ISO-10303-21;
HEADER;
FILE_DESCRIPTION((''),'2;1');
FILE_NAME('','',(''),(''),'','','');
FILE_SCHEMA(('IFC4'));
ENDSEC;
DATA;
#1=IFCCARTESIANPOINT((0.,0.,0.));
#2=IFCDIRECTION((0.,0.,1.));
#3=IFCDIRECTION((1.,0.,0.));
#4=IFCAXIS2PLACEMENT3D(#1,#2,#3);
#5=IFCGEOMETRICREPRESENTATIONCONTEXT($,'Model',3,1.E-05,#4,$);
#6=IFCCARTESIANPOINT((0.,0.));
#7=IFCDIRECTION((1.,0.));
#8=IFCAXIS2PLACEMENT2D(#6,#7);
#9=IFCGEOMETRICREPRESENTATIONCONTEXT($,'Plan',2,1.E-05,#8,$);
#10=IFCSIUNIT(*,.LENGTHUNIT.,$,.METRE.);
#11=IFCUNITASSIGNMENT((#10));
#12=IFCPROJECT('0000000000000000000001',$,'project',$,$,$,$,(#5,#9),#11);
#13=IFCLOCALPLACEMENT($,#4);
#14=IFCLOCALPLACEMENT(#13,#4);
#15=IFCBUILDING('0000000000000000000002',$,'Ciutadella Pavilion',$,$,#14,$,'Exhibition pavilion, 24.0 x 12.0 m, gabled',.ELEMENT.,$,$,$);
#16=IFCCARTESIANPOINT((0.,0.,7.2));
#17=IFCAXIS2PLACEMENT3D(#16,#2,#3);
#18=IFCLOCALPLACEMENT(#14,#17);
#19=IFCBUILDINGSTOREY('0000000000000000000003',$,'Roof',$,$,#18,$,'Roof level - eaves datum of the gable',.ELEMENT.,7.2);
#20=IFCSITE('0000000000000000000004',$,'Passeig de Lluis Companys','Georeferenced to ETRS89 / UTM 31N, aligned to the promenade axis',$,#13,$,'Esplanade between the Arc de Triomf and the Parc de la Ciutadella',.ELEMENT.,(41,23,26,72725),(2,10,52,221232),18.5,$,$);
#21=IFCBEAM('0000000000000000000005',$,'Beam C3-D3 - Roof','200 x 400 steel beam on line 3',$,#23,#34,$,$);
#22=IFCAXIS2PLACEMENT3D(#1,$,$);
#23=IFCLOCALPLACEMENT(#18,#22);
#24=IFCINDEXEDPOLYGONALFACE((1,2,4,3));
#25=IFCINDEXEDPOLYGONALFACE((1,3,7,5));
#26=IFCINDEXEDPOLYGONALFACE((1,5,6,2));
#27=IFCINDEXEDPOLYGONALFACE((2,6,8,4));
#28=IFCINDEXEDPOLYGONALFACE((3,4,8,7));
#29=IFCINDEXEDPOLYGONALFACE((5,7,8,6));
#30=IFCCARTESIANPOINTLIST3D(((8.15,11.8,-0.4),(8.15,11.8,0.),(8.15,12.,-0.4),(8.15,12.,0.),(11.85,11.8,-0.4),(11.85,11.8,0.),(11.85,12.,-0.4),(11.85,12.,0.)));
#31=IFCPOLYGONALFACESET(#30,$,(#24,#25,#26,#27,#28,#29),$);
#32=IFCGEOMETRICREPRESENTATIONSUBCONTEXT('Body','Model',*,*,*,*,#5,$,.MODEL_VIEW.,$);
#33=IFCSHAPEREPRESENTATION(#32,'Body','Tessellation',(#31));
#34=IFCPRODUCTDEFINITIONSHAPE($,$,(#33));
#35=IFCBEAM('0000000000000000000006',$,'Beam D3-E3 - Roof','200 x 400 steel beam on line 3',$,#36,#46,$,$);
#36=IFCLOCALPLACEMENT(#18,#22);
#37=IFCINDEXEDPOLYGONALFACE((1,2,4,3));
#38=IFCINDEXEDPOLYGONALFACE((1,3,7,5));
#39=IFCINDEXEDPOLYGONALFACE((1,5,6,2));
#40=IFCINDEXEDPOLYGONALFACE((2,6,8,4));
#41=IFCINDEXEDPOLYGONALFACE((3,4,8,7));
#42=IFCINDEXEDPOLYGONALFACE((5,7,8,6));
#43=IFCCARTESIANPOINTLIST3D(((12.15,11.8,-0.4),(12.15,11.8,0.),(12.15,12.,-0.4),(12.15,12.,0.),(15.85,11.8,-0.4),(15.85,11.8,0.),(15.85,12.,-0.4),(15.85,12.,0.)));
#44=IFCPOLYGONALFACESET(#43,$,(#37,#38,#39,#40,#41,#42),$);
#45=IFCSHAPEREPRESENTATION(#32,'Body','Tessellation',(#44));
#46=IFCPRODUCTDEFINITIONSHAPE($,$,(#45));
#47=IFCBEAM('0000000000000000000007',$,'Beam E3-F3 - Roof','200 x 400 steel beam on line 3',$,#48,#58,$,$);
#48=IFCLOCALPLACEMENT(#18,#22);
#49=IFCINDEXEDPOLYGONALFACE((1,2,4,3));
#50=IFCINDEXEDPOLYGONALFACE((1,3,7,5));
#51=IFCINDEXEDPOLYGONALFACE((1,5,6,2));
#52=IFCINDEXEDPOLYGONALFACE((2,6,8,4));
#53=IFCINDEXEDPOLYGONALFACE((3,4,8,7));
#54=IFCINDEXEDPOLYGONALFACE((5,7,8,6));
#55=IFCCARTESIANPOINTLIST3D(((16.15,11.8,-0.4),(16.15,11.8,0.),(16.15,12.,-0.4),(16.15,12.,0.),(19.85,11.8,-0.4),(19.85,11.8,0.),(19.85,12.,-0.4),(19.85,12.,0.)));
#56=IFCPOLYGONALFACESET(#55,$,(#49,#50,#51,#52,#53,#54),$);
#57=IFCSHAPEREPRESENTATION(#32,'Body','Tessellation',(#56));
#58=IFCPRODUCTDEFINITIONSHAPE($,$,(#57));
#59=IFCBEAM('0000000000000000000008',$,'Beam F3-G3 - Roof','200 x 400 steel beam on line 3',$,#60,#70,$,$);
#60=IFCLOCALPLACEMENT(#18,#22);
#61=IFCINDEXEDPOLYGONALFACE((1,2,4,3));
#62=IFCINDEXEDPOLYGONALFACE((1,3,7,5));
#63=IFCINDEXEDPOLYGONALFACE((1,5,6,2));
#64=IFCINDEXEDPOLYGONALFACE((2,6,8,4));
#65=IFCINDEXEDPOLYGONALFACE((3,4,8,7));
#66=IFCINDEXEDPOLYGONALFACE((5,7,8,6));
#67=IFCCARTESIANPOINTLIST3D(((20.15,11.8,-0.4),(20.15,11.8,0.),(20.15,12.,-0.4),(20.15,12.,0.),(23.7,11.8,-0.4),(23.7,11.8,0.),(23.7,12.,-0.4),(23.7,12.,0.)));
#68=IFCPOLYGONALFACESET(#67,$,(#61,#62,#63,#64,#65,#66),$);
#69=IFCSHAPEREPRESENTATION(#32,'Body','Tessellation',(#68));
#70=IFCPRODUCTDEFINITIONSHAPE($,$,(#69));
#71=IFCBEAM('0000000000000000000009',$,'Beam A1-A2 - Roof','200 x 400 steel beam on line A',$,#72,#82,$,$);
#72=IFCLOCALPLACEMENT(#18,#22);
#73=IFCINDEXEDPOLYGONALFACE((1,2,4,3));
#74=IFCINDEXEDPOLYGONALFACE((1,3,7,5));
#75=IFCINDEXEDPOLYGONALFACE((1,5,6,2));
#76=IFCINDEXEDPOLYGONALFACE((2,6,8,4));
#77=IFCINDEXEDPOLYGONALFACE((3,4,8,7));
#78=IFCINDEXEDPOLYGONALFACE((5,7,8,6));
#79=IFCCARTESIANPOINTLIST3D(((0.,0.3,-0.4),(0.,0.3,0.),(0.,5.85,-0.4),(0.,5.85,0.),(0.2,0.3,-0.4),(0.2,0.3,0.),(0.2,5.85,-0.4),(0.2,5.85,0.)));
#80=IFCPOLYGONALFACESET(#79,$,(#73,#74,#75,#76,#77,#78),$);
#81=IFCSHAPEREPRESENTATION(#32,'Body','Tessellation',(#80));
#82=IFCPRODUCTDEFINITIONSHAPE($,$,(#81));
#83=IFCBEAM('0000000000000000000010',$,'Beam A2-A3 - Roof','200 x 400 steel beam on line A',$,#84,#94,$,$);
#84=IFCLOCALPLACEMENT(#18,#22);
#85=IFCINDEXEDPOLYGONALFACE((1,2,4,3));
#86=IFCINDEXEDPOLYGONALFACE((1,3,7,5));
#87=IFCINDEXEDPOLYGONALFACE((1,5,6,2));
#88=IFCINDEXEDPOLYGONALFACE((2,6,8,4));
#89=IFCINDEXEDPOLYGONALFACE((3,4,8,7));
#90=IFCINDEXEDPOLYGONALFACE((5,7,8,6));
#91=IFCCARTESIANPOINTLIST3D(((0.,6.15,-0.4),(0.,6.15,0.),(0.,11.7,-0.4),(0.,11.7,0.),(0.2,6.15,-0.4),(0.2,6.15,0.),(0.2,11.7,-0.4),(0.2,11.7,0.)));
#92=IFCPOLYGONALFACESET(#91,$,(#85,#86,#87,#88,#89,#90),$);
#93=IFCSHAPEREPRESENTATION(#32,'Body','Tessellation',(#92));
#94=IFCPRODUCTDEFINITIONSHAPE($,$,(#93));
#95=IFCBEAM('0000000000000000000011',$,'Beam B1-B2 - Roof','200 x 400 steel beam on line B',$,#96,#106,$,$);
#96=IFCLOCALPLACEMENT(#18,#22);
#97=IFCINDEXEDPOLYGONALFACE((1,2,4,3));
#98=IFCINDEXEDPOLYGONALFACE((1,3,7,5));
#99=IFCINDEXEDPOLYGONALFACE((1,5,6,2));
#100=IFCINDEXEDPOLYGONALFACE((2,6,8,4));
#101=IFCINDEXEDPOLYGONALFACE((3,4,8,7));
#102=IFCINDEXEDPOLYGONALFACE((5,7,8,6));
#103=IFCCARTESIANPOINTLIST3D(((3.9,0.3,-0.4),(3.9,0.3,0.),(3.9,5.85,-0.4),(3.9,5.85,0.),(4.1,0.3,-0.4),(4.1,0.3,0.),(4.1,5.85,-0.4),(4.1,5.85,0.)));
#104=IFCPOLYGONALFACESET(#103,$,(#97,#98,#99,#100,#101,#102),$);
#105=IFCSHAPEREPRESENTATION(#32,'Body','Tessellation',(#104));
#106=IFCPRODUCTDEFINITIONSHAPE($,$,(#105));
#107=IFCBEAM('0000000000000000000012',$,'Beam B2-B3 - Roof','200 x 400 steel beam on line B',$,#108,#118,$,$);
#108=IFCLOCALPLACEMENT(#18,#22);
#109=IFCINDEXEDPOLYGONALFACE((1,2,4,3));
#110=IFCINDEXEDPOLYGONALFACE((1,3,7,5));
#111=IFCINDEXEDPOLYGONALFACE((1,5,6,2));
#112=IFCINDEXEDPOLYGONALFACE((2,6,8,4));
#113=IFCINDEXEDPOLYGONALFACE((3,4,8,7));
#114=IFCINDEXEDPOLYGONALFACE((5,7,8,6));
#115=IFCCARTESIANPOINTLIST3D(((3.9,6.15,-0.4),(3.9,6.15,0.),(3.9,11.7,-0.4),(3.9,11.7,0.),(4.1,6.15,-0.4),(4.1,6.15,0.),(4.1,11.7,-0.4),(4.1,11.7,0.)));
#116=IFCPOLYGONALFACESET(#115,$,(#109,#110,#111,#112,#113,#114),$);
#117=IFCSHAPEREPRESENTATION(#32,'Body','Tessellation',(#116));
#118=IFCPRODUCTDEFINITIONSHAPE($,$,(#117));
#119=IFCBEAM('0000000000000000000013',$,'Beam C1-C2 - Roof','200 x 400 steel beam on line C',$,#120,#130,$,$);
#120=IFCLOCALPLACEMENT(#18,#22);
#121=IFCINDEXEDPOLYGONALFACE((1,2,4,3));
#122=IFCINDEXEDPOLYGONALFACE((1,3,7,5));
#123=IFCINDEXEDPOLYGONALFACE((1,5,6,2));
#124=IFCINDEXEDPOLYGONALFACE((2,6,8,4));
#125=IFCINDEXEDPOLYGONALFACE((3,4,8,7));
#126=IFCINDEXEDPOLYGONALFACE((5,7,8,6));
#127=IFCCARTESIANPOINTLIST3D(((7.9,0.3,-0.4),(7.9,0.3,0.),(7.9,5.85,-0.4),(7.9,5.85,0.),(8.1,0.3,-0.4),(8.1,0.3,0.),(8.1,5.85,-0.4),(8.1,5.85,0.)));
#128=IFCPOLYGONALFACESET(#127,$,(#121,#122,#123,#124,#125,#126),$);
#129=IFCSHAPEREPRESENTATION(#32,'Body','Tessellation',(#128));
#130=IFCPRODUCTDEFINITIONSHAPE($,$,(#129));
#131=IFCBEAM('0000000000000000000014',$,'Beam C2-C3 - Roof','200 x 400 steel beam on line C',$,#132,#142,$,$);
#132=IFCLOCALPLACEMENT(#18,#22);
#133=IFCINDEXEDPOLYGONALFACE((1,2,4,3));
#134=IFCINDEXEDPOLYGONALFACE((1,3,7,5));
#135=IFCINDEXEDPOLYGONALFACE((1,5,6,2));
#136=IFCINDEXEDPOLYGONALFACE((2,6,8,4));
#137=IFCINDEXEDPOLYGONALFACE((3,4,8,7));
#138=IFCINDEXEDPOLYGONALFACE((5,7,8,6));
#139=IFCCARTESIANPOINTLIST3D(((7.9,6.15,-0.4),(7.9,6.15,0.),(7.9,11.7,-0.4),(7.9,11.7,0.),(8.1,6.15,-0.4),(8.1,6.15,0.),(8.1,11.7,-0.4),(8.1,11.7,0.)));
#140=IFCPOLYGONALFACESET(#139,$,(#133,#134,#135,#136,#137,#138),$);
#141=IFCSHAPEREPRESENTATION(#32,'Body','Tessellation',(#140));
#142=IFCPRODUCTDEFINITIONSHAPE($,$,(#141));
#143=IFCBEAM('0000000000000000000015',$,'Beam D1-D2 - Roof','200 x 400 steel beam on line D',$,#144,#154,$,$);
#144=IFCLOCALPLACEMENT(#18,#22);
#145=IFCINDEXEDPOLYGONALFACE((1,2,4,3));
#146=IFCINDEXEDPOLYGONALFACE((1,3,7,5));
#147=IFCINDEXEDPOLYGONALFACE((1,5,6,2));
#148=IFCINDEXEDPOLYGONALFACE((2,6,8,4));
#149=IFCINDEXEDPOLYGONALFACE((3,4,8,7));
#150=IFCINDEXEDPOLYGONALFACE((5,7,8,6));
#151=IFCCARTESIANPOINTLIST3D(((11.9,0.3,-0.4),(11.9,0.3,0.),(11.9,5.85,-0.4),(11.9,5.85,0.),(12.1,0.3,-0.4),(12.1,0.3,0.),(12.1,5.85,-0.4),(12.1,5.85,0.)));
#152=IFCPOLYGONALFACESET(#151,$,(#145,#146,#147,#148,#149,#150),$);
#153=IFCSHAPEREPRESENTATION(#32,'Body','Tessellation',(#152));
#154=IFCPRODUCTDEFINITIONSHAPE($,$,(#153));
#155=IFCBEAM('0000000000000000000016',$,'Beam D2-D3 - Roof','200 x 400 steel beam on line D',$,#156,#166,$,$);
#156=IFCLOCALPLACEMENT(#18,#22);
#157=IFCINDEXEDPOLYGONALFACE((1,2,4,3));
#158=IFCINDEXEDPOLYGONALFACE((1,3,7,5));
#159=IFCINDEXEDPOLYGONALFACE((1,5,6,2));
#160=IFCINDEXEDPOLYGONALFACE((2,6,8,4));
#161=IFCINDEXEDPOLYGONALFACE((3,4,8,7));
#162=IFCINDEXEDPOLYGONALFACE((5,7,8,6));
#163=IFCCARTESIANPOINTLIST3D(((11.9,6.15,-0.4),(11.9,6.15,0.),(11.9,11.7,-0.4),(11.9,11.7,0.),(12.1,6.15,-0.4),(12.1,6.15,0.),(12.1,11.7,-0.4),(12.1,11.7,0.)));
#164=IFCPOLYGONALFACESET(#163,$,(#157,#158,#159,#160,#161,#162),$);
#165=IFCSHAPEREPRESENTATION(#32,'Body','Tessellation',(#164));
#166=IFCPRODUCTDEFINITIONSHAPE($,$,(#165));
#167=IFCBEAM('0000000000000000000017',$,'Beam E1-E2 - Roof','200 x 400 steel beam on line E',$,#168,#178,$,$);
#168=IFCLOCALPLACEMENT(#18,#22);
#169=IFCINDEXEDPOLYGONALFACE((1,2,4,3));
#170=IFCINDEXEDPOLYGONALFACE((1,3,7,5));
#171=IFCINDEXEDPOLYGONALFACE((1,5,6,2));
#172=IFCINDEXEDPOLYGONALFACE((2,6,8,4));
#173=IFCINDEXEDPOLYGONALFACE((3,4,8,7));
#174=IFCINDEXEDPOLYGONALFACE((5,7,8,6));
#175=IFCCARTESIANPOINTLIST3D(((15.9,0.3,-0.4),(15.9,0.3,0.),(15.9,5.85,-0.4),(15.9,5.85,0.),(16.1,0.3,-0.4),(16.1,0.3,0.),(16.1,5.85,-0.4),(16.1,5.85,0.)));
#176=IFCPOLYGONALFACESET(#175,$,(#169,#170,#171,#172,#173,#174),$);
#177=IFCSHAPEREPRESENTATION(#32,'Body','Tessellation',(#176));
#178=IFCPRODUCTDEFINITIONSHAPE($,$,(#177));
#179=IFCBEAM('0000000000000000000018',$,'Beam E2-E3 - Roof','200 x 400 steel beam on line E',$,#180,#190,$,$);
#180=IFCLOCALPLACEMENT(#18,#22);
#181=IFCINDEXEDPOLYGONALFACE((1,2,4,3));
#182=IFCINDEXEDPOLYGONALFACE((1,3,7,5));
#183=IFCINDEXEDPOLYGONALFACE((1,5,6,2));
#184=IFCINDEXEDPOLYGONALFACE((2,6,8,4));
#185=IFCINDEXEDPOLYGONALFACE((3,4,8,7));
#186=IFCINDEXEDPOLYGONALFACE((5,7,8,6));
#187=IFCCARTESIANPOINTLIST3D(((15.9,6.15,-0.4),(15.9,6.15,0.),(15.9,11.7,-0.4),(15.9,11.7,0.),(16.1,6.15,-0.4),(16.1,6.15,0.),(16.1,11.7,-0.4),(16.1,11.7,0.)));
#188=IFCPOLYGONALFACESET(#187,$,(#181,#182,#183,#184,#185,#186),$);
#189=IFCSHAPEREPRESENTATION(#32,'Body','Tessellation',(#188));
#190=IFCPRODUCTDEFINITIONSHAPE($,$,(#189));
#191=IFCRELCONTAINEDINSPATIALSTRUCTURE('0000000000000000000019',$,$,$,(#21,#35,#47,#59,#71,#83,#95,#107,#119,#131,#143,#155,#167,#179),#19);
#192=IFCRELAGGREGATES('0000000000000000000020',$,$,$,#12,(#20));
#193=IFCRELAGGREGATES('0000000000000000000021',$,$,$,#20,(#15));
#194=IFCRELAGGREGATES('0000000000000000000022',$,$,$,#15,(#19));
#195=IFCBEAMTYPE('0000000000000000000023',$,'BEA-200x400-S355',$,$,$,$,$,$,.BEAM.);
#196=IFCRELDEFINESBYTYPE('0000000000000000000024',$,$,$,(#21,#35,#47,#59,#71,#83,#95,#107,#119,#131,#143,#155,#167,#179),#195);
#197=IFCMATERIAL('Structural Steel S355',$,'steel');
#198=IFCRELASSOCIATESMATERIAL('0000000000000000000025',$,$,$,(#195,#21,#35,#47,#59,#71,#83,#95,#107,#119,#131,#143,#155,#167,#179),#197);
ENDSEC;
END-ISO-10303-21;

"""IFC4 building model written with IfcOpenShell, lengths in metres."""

from ifc_helpers import new_model, si_unit, frame, origin_with_axes, origin_2d_with_axis, place, context, subcontext, project, spatial, line, indexed_curve, rectangle, outline, extrude, material, material_profile, profile_set, profile_usage, type_object, element, save


model = new_model("IFC4")

# Units and contexts
model_context = context("Model", 3, precision=1e-05, world=origin_with_axes())
plan_context = context("Plan", 2, precision=1e-05, world=origin_2d_with_axis())
body_context = subcontext(model_context, "Body", "Model", "MODEL_VIEW")
ifc_project = project(units=[si_unit("LENGTHUNIT", "METRE")], contexts=[model_context, plan_context])

# Site, building, storey
site_placement = place(None, origin_with_axes())
site = spatial("IfcSite", under=ifc_project, at=site_placement, Name="Passeig de Lluis Companys", Description="Georeferenced to ETRS89 / UTM 31N, aligned to the promenade axis", LongName="Esplanade between the Arc de Triomf and the Parc de la Ciutadella", CompositionType="ELEMENT", RefLatitude=(41, 23, 26, 72725), RefLongitude=(2, 10, 52, 221232), RefElevation=18.5)
building_placement = place(site_placement, origin_with_axes())
building = spatial("IfcBuilding", under=site, at=building_placement, Name="Ciutadella Pavilion", LongName="Exhibition pavilion, 24.0 x 12.0 m, gabled", CompositionType="ELEMENT")
storey_placement = place(building_placement, frame((0.0, 0.0, 7.2), z_axis=(0.0, 0.0, 1.0), x_axis=(1.0, 0.0, 0.0)))
storey = spatial("IfcBuildingStorey", under=building, at=storey_placement, Name="Roof", LongName="Roof level - eaves datum of the gable", CompositionType="ELEMENT", Elevation=7.2)

# Beams
ifc_material_1 = material(Name="Structural Steel S355", Category="steel")
ifc_material_profile = material_profile(ifc_material_1, rectangle(XDim=0.2, YDim=0.4))
ifc_profile_set = profile_set([ifc_material_profile], Name="BEA-200x400-S355")
beam_type = type_object("IfcBeamType", Name="BEA-200x400-S355", PredefinedType="BEAM", material=ifc_profile_set)
ifc_profile_usage_1 = profile_usage(ifc_profile_set)
beam_1_placement = place(storey_placement, frame((8.15, 11.8, -0.4), z_axis=(1.0, 0.0, 0.0), x_axis=(0.0, 1.0, 0.0)))
element("IfcBeam", 1, at=beam_1_placement, inside=storey, type_object=beam_type, material=ifc_profile_usage_1, Name="Beam C3-D3 - Roof", Description="200 x 400 steel beam on line 3", context=body_context, shape_type="SweptSolid", body=[
    extrude(outline(indexed_curve([(0.0, 0.0), (0.2, 0.0), (0.2, 0.4), (0.0, 0.4)], segments=[line(1, 2, 3, 4, 1)])), origin_with_axes(), (0.0, 0.0, 1.0), 3.7),
])
ifc_profile_usage_2 = profile_usage(ifc_profile_set)
beam_2_placement = place(storey_placement, frame((12.15, 11.8, -0.4), z_axis=(1.0, 0.0, 0.0), x_axis=(0.0, 1.0, 0.0)))
element("IfcBeam", 2, at=beam_2_placement, inside=storey, type_object=beam_type, material=ifc_profile_usage_2, Name="Beam D3-E3 - Roof", Description="200 x 400 steel beam on line 3", context=body_context, shape_type="SweptSolid", body=[
    extrude(outline(indexed_curve([(0.0, 0.0), (0.2, 0.0), (0.2, 0.4), (0.0, 0.4)], segments=[line(1, 2, 3, 4, 1)])), origin_with_axes(), (0.0, 0.0, 1.0), 3.7),
])
ifc_profile_usage_3 = profile_usage(ifc_profile_set)
beam_3_placement = place(storey_placement, frame((16.15, 11.8, -0.4), z_axis=(1.0, 0.0, 0.0), x_axis=(0.0, 1.0, 0.0)))
element("IfcBeam", 3, at=beam_3_placement, inside=storey, type_object=beam_type, material=ifc_profile_usage_3, Name="Beam E3-F3 - Roof", Description="200 x 400 steel beam on line 3", context=body_context, shape_type="SweptSolid", body=[
    extrude(outline(indexed_curve([(0.0, 0.0), (0.2, 0.0), (0.2, 0.4), (0.0, 0.4)], segments=[line(1, 2, 3, 4, 1)])), origin_with_axes(), (0.0, 0.0, 1.0), 3.7),
])
ifc_profile_usage_4 = profile_usage(ifc_profile_set)
beam_4_placement = place(storey_placement, frame((20.15, 11.8, -0.4), z_axis=(1.0, 0.0, 0.0), x_axis=(0.0, 1.0, 0.0)))
element("IfcBeam", 4, at=beam_4_placement, inside=storey, type_object=beam_type, material=ifc_profile_usage_4, Name="Beam F3-G3 - Roof", Description="200 x 400 steel beam on line 3", context=body_context, shape_type="SweptSolid", body=[
    extrude(outline(indexed_curve([(0.0, 0.0), (0.2, 0.0), (0.2, 0.4), (0.0, 0.4)], segments=[line(1, 2, 3, 4, 1)])), origin_with_axes(), (0.0, 0.0, 1.0), 3.55),
])
ifc_profile_usage_5 = profile_usage(ifc_profile_set)
beam_5_placement = place(storey_placement, frame((0.0, 0.3, -0.4), z_axis=(0.0, 1.0, 0.0), x_axis=(0.0, 0.0, 1.0)))
element("IfcBeam", 5, at=beam_5_placement, inside=storey, type_object=beam_type, material=ifc_profile_usage_5, Name="Beam A1-A2 - Roof", Description="200 x 400 steel beam on line A", context=body_context, shape_type="SweptSolid", body=[
    extrude(outline(indexed_curve([(0.0, 0.0), (0.4, 0.0), (0.4, 0.2), (0.0, 0.2)], segments=[line(1, 2, 3, 4, 1)])), origin_with_axes(), (0.0, 0.0, 1.0), 5.55),
])
ifc_profile_usage_6 = profile_usage(ifc_profile_set)
beam_6_placement = place(storey_placement, frame((0.0, 6.15, -0.4), z_axis=(0.0, 1.0, 0.0), x_axis=(0.0, 0.0, 1.0)))
element("IfcBeam", 6, at=beam_6_placement, inside=storey, type_object=beam_type, material=ifc_profile_usage_6, Name="Beam A2-A3 - Roof", Description="200 x 400 steel beam on line A", context=body_context, shape_type="SweptSolid", body=[
    extrude(outline(indexed_curve([(0.0, 0.0), (0.4, 0.0), (0.4, 0.2), (0.0, 0.2)], segments=[line(1, 2, 3, 4, 1)])), origin_with_axes(), (0.0, 0.0, 1.0), 5.55),
])
ifc_profile_usage_7 = profile_usage(ifc_profile_set)
beam_7_placement = place(storey_placement, frame((3.9, 0.3, -0.4), z_axis=(0.0, 1.0, 0.0), x_axis=(0.0, 0.0, 1.0)))
element("IfcBeam", 7, at=beam_7_placement, inside=storey, type_object=beam_type, material=ifc_profile_usage_7, Name="Beam B1-B2 - Roof", Description="200 x 400 steel beam on line B", context=body_context, shape_type="SweptSolid", body=[
    extrude(outline(indexed_curve([(0.0, 0.0), (0.4, 0.0), (0.4, 0.2), (0.0, 0.2)], segments=[line(1, 2, 3, 4, 1)])), origin_with_axes(), (0.0, 0.0, 1.0), 5.55),
])
ifc_profile_usage_8 = profile_usage(ifc_profile_set)
beam_8_placement = place(storey_placement, frame((3.9, 6.15, -0.4), z_axis=(0.0, 1.0, 0.0), x_axis=(0.0, 0.0, 1.0)))
element("IfcBeam", 8, at=beam_8_placement, inside=storey, type_object=beam_type, material=ifc_profile_usage_8, Name="Beam B2-B3 - Roof", Description="200 x 400 steel beam on line B", context=body_context, shape_type="SweptSolid", body=[
    extrude(outline(indexed_curve([(0.0, 0.0), (0.4, 0.0), (0.4, 0.2), (0.0, 0.2)], segments=[line(1, 2, 3, 4, 1)])), origin_with_axes(), (0.0, 0.0, 1.0), 5.55),
])
ifc_profile_usage_9 = profile_usage(ifc_profile_set)
beam_9_placement = place(storey_placement, frame((7.9, 0.3, -0.4), z_axis=(0.0, 1.0, 0.0), x_axis=(0.0, 0.0, 1.0)))
element("IfcBeam", 9, at=beam_9_placement, inside=storey, type_object=beam_type, material=ifc_profile_usage_9, Name="Beam C1-C2 - Roof", Description="200 x 400 steel beam on line C", context=body_context, shape_type="SweptSolid", body=[
    extrude(outline(indexed_curve([(0.0, 0.0), (0.4, 0.0), (0.4, 0.2), (0.0, 0.2)], segments=[line(1, 2, 3, 4, 1)])), origin_with_axes(), (0.0, 0.0, 1.0), 5.55),
])
ifc_profile_usage_10 = profile_usage(ifc_profile_set)
beam_10_placement = place(storey_placement, frame((7.9, 6.15, -0.4), z_axis=(0.0, 1.0, 0.0), x_axis=(0.0, 0.0, 1.0)))
element("IfcBeam", 10, at=beam_10_placement, inside=storey, type_object=beam_type, material=ifc_profile_usage_10, Name="Beam C2-C3 - Roof", Description="200 x 400 steel beam on line C", context=body_context, shape_type="SweptSolid", body=[
    extrude(outline(indexed_curve([(0.0, 0.0), (0.4, 0.0), (0.4, 0.2), (0.0, 0.2)], segments=[line(1, 2, 3, 4, 1)])), origin_with_axes(), (0.0, 0.0, 1.0), 5.55),
])
ifc_profile_usage_11 = profile_usage(ifc_profile_set)
beam_11_placement = place(storey_placement, frame((11.9, 0.3, -0.4), z_axis=(0.0, 1.0, 0.0), x_axis=(0.0, 0.0, 1.0)))
element("IfcBeam", 11, at=beam_11_placement, inside=storey, type_object=beam_type, material=ifc_profile_usage_11, Name="Beam D1-D2 - Roof", Description="200 x 400 steel beam on line D", context=body_context, shape_type="SweptSolid", body=[
    extrude(outline(indexed_curve([(0.0, 0.0), (0.4, 0.0), (0.4, 0.2), (0.0, 0.2)], segments=[line(1, 2, 3, 4, 1)])), origin_with_axes(), (0.0, 0.0, 1.0), 5.55),
])
ifc_profile_usage_12 = profile_usage(ifc_profile_set)
beam_12_placement = place(storey_placement, frame((11.9, 6.15, -0.4), z_axis=(0.0, 1.0, 0.0), x_axis=(0.0, 0.0, 1.0)))
element("IfcBeam", 12, at=beam_12_placement, inside=storey, type_object=beam_type, material=ifc_profile_usage_12, Name="Beam D2-D3 - Roof", Description="200 x 400 steel beam on line D", context=body_context, shape_type="SweptSolid", body=[
    extrude(outline(indexed_curve([(0.0, 0.0), (0.4, 0.0), (0.4, 0.2), (0.0, 0.2)], segments=[line(1, 2, 3, 4, 1)])), origin_with_axes(), (0.0, 0.0, 1.0), 5.55),
])
ifc_profile_usage_13 = profile_usage(ifc_profile_set)
beam_13_placement = place(storey_placement, frame((15.9, 0.3, -0.4), z_axis=(0.0, 1.0, 0.0), x_axis=(0.0, 0.0, 1.0)))
element("IfcBeam", 13, at=beam_13_placement, inside=storey, type_object=beam_type, material=ifc_profile_usage_13, Name="Beam E1-E2 - Roof", Description="200 x 400 steel beam on line E", context=body_context, shape_type="SweptSolid", body=[
    extrude(outline(indexed_curve([(0.0, 0.0), (0.4, 0.0), (0.4, 0.2), (0.0, 0.2)], segments=[line(1, 2, 3, 4, 1)])), origin_with_axes(), (0.0, 0.0, 1.0), 5.55),
])
ifc_profile_usage_14 = profile_usage(ifc_profile_set)
beam_14_placement = place(storey_placement, frame((15.9, 6.15, -0.4), z_axis=(0.0, 1.0, 0.0), x_axis=(0.0, 0.0, 1.0)))
element("IfcBeam", 14, at=beam_14_placement, inside=storey, type_object=beam_type, material=ifc_profile_usage_14, Name="Beam E2-E3 - Roof", Description="200 x 400 steel beam on line E", context=body_context, shape_type="SweptSolid", body=[
    extrude(outline(indexed_curve([(0.0, 0.0), (0.4, 0.0), (0.4, 0.2), (0.0, 0.2)], segments=[line(1, 2, 3, 4, 1)])), origin_with_axes(), (0.0, 0.0, 1.0), 5.55),
])

save(model, "model.ifc")
